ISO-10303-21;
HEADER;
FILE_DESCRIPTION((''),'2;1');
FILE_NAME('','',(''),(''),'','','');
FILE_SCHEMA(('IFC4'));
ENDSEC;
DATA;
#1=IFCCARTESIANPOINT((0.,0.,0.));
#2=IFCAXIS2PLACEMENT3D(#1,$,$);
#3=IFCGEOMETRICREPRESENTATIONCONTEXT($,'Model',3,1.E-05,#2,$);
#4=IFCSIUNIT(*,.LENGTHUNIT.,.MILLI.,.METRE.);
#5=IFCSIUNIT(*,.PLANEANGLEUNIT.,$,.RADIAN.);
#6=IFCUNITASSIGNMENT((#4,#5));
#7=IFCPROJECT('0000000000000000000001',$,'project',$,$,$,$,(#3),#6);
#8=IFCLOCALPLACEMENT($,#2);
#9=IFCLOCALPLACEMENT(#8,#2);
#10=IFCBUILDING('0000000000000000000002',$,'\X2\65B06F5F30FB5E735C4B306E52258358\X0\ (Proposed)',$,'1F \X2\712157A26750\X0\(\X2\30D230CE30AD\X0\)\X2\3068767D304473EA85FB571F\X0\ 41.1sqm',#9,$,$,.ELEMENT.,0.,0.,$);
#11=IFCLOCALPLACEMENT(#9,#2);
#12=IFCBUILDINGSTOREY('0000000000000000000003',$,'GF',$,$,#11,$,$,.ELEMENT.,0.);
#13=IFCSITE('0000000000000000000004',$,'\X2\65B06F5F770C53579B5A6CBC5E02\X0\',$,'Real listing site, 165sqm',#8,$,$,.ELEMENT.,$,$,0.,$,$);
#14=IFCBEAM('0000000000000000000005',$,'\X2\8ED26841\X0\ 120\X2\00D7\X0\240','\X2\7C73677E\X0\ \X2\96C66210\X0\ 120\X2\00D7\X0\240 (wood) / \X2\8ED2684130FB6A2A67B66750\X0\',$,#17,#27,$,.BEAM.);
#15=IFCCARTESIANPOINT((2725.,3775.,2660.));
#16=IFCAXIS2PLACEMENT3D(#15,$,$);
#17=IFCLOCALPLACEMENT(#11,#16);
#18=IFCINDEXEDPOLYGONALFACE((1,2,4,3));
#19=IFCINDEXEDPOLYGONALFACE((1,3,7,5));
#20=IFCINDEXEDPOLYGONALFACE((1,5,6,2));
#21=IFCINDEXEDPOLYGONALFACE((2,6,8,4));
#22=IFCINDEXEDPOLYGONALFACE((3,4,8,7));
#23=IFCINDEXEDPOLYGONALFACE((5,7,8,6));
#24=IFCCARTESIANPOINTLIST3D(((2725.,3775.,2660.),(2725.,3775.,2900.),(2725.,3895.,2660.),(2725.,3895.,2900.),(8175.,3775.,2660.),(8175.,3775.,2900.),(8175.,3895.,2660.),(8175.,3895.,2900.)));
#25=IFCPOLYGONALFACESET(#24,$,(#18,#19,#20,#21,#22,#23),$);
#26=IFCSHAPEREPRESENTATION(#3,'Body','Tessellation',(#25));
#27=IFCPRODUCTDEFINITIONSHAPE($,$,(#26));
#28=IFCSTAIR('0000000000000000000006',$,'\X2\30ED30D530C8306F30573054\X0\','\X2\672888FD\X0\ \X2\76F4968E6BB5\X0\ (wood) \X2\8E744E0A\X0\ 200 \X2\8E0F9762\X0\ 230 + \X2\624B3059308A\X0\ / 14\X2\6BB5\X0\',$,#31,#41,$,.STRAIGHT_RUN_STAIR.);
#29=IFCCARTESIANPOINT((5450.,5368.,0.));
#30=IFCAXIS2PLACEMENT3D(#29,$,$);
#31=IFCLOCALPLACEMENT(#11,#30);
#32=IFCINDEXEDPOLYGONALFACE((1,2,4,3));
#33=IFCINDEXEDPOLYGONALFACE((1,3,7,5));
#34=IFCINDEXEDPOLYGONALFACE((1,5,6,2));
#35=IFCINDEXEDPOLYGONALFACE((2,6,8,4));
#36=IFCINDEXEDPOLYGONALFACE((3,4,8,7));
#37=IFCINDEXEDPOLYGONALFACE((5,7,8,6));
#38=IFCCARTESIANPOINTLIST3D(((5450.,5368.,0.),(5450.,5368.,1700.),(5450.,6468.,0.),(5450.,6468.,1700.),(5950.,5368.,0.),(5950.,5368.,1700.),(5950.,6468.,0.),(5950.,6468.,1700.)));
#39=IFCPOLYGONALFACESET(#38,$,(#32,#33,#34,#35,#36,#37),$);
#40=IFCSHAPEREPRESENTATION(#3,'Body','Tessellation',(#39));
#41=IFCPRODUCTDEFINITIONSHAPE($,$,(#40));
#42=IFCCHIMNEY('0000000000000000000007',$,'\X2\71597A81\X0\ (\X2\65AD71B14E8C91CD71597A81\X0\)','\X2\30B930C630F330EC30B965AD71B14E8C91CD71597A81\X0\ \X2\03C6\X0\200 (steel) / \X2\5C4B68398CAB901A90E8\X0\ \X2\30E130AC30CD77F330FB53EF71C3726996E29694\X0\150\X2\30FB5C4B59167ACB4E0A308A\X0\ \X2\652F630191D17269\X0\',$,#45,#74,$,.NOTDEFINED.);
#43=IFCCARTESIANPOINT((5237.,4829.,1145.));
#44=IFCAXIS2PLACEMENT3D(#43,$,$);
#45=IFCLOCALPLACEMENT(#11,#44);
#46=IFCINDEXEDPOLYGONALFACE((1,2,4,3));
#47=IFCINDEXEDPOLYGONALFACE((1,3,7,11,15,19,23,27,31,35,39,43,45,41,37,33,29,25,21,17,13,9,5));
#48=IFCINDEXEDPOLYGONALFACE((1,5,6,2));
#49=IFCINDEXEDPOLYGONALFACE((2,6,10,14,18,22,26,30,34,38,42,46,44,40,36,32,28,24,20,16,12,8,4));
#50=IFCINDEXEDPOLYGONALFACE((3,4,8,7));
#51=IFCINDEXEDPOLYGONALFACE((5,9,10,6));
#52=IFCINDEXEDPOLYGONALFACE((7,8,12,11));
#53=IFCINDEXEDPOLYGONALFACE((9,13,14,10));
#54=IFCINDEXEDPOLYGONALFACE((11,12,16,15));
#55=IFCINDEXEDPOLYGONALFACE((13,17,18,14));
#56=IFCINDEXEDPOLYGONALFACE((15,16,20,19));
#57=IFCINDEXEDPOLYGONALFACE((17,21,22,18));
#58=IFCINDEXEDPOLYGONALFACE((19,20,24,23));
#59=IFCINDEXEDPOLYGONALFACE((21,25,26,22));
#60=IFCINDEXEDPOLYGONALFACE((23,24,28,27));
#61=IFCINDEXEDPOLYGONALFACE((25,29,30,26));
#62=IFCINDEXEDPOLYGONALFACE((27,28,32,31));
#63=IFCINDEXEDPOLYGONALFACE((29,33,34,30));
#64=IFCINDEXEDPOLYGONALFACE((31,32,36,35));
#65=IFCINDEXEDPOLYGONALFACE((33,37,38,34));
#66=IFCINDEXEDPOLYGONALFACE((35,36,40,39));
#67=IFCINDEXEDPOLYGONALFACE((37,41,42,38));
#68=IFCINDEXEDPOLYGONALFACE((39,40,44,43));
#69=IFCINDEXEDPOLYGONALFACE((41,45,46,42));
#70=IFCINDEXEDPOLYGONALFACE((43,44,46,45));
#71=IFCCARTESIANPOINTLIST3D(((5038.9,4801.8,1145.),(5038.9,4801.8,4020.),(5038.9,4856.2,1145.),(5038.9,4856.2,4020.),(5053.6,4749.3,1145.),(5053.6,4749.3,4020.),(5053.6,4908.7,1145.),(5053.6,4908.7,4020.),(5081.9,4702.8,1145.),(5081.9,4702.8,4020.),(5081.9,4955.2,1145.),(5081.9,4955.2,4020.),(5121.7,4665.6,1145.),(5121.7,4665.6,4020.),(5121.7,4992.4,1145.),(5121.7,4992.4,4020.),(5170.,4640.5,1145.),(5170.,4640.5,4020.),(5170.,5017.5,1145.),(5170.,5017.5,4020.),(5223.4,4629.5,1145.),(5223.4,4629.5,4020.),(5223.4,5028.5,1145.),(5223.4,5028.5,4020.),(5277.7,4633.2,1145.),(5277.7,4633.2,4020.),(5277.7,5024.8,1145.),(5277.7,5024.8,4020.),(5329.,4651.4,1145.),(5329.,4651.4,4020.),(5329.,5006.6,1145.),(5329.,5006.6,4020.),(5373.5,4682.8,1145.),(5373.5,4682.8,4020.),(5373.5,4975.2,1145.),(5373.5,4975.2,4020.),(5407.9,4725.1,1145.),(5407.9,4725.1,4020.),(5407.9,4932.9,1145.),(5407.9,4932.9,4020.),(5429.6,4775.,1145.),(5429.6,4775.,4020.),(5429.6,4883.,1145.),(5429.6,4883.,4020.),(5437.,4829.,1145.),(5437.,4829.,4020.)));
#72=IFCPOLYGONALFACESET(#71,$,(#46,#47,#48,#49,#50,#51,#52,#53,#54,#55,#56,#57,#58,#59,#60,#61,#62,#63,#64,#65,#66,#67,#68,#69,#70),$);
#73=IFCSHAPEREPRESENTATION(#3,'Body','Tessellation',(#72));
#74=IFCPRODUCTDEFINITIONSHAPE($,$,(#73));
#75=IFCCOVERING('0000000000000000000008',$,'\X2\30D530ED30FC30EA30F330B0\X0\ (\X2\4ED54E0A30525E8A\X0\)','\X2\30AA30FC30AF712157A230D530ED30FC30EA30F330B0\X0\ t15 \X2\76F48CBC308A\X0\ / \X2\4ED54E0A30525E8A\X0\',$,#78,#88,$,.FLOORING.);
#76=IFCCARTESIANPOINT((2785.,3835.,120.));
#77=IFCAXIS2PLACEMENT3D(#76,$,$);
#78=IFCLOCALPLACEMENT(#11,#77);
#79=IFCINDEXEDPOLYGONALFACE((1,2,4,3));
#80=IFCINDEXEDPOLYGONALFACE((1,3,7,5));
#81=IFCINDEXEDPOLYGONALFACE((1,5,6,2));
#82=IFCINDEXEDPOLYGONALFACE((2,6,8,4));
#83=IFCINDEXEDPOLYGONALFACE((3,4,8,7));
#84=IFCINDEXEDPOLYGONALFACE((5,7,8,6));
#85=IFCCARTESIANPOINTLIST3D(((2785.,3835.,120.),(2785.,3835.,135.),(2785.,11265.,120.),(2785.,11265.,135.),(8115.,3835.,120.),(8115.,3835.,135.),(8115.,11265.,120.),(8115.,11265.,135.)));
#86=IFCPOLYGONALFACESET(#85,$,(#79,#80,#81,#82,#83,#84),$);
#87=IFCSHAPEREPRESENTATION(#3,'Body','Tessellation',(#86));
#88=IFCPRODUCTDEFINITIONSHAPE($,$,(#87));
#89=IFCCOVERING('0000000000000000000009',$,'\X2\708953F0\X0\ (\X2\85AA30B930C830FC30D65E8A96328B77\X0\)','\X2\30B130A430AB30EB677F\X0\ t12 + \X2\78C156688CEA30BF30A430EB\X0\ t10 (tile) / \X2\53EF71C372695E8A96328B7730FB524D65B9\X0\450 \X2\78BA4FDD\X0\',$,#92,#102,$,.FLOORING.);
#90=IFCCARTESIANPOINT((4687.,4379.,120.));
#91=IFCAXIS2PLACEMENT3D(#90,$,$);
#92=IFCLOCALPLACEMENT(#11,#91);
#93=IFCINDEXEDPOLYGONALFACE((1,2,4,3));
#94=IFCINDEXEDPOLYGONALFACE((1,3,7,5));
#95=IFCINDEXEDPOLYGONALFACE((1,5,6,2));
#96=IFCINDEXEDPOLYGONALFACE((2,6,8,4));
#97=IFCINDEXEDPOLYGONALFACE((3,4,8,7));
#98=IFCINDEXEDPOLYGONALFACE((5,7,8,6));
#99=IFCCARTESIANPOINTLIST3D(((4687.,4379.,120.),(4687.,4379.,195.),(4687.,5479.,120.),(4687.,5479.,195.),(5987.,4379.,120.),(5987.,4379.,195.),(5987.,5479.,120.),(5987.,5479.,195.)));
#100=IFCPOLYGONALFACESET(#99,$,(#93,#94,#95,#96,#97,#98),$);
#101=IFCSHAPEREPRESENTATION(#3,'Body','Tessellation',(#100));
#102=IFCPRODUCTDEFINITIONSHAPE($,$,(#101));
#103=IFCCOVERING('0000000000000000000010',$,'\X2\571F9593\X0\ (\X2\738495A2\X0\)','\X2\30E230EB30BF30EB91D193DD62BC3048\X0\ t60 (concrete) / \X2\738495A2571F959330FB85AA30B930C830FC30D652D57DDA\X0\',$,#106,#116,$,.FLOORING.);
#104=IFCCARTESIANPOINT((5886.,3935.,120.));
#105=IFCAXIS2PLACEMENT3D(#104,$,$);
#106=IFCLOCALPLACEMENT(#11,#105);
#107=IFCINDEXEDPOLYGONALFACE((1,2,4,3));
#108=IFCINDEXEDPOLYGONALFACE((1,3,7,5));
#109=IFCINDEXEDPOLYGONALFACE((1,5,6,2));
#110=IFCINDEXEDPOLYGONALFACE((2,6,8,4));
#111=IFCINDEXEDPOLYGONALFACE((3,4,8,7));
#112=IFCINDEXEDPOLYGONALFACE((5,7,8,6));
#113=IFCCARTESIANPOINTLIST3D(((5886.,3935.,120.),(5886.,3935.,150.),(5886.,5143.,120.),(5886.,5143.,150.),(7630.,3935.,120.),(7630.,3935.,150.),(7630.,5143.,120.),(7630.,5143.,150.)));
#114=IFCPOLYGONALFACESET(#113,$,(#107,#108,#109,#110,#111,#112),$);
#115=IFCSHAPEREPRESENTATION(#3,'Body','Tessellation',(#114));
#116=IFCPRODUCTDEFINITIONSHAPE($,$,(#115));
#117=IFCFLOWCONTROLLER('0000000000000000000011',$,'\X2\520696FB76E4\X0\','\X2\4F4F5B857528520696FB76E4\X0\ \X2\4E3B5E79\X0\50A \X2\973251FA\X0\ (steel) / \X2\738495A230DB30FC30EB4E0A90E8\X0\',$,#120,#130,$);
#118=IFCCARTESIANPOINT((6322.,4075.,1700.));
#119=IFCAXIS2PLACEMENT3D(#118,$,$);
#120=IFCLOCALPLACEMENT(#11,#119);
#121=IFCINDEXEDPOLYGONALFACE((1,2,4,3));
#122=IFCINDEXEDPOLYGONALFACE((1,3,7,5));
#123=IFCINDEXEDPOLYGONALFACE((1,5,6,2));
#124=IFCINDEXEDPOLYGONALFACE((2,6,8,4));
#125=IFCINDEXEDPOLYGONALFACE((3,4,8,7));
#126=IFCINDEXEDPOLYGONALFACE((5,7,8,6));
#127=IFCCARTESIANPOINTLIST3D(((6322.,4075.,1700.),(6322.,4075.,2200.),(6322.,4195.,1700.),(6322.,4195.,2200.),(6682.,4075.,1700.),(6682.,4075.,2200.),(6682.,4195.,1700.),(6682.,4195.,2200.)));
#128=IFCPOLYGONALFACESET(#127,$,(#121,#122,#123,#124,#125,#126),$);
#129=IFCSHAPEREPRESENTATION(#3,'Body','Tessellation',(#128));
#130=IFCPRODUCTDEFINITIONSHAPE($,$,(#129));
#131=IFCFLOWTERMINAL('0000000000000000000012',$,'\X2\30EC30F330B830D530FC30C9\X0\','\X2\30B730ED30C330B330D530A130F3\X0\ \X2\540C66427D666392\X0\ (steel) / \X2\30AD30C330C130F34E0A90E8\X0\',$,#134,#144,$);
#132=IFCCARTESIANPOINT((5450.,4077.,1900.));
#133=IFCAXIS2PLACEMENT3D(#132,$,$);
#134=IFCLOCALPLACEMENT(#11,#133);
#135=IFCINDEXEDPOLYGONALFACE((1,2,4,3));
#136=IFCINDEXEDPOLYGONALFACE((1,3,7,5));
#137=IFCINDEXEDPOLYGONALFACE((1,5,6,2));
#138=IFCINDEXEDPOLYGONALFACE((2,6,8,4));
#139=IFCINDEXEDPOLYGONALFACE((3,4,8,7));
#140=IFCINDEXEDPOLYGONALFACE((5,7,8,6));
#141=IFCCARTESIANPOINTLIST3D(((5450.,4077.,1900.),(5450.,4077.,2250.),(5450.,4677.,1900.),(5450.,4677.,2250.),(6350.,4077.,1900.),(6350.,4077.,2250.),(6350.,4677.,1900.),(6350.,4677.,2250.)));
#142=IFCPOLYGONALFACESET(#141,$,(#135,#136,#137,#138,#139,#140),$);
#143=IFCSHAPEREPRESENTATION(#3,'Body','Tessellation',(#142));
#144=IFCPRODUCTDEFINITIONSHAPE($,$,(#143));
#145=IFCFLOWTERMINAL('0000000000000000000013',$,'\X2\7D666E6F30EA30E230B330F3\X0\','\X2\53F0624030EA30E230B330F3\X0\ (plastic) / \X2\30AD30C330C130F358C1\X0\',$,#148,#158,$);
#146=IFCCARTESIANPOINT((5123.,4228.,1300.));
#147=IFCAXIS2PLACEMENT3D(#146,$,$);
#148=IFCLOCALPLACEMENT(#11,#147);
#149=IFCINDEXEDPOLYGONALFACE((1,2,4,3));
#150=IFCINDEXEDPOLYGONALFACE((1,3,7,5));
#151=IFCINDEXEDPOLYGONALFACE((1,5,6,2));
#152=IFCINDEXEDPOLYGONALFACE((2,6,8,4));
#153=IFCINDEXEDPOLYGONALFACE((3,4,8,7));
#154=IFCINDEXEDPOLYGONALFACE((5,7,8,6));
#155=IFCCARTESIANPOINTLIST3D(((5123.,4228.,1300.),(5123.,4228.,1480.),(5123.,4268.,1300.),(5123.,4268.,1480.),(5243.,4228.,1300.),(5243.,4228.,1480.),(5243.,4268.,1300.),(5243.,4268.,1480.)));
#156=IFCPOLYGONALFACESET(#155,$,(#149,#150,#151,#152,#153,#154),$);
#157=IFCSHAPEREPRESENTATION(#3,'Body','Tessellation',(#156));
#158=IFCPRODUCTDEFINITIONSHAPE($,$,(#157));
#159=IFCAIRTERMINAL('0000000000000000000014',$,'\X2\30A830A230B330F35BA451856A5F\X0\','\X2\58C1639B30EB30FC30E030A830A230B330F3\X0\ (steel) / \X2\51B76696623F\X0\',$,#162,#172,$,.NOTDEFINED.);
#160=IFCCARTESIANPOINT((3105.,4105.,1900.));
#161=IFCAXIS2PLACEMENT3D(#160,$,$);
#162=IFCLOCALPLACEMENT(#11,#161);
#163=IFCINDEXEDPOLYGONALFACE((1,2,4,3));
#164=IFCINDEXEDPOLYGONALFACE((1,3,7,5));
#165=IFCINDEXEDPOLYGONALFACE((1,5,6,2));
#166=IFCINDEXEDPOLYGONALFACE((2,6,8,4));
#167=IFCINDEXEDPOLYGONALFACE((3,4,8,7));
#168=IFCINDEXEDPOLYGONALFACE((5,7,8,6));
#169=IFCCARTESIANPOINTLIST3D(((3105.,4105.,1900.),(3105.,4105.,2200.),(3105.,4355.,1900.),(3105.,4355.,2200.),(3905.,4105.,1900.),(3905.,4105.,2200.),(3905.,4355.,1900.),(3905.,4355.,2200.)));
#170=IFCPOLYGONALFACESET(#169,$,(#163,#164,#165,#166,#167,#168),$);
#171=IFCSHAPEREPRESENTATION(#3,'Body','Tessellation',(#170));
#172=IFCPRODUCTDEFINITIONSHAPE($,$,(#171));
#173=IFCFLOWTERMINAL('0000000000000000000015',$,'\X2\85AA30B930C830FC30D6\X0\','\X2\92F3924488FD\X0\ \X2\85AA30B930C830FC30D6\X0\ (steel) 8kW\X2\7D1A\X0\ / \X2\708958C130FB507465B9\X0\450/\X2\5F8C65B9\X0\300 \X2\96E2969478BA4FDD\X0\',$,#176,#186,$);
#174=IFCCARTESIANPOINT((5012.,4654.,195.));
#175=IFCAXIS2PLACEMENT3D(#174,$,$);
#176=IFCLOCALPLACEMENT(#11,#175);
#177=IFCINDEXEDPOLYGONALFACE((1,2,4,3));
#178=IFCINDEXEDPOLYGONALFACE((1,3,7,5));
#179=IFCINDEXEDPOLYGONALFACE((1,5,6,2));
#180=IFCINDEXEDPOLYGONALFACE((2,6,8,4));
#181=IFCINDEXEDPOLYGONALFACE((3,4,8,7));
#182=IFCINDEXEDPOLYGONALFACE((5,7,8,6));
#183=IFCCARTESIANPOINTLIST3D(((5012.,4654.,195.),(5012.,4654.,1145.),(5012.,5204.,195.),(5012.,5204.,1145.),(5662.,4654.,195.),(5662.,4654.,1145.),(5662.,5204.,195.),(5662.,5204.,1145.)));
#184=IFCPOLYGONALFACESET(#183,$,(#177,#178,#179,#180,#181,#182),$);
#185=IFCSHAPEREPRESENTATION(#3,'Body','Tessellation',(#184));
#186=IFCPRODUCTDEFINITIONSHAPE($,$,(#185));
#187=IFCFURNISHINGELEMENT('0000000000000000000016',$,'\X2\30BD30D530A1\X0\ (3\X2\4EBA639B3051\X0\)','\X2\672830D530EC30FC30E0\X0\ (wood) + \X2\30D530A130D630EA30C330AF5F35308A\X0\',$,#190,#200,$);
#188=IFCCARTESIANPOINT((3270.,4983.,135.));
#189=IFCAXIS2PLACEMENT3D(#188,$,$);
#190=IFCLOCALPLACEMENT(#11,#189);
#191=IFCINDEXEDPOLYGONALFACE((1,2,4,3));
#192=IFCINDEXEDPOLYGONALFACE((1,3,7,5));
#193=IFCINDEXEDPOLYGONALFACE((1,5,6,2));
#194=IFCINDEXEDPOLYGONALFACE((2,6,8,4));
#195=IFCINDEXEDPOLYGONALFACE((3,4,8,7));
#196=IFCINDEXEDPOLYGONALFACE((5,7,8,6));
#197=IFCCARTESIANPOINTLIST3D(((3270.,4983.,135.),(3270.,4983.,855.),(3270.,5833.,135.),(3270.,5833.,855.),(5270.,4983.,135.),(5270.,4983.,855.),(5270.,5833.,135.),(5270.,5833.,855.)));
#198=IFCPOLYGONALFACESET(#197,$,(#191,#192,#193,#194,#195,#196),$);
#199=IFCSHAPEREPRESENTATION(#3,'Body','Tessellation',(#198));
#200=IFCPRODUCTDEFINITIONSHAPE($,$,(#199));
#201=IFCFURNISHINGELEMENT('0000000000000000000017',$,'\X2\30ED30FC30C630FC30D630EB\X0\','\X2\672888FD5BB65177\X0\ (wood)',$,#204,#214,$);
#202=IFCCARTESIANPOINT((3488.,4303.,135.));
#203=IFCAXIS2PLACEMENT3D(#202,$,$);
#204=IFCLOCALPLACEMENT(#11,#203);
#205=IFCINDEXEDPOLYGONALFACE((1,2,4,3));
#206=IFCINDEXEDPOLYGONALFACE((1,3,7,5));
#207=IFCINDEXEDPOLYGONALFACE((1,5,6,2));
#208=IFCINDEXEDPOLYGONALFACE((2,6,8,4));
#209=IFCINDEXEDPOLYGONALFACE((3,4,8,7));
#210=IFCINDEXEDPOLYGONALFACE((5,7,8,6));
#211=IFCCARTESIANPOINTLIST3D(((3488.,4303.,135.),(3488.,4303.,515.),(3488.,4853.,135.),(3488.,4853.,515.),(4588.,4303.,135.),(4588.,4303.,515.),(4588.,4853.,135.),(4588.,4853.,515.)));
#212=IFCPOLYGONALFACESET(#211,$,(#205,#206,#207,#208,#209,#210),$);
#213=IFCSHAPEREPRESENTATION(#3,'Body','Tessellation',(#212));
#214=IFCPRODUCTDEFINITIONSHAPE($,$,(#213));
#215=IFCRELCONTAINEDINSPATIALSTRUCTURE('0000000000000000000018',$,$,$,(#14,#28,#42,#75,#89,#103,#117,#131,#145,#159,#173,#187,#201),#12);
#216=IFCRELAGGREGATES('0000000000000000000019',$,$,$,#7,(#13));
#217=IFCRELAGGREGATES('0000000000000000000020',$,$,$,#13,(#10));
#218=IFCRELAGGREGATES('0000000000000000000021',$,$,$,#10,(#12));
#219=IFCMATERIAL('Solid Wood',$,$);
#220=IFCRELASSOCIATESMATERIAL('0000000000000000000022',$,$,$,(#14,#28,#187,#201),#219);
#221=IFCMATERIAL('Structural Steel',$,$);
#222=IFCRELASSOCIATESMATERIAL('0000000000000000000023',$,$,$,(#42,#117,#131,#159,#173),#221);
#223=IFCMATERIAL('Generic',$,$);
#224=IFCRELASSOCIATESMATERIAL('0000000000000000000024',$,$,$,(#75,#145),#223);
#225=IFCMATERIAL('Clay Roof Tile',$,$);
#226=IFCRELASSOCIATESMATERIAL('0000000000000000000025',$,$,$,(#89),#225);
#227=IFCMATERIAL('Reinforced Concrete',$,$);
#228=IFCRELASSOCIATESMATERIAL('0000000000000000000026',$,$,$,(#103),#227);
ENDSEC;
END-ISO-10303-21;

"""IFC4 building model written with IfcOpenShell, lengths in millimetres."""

from ifc_helpers import new_model, si_unit, frame, frame_2d, origin, origin_2d, place, context, project, spatial, rectangle, circle, extrude, material, element, save


model = new_model("IFC4")

# Units and contexts
model_context = context("Model", 3, precision=1e-05, world=origin())
ifc_project = project(units=[si_unit("LENGTHUNIT", "METRE", prefix="MILLI"), si_unit("PLANEANGLEUNIT", "RADIAN")], contexts=[model_context])

# Site, building, storey
site_placement = place(None, origin())
site = spatial("IfcSite", under=ifc_project, at=site_placement, Name="新潟県南魚沼市", ObjectType="Real listing site, 165sqm", CompositionType="ELEMENT", RefElevation=0.0)
building_placement = place(site_placement, origin())
building = spatial("IfcBuilding", under=site, at=building_placement, Name="新潟・平屋の別荘 (Proposed)", ObjectType="1F 無垢材(ヒノキ)と白い珪藻土 41.1sqm", CompositionType="ELEMENT", ElevationOfRefHeight=0.0, ElevationOfTerrain=0.0)
storey_placement = place(building_placement, origin())
storey = spatial("IfcBuildingStorey", under=building, at=storey_placement, Name="GF", CompositionType="ELEMENT", Elevation=0.0)

# Beam
ifc_material_1 = material(Name="Solid Wood")
beam_1_placement = place(storey_placement, frame((2725.0, 3775.0, 2660.0)))
element("IfcBeam", 1, at=beam_1_placement, inside=storey, material=ifc_material_1, Name="軒桁 120×240", Description="米松 集成 120×240 (wood) / 軒桁・横架材", PredefinedType="BEAM", context=model_context, shape_type="SweptSolid", body=[
    extrude(rectangle(XDim=5450.0, YDim=120.0, at=frame_2d((2725.0, 60.0))), frame((2725.0, 3775.0, 2660.0)), (0.0, 0.0, 1.0), 240.0),
])

# Stair
stair_placement = place(storey_placement, frame((5450.0, 5368.0, 0.0)))
element("IfcStair", 2, at=stair_placement, inside=storey, material=ifc_material_1, Name="ロフトはしご", Description="木製 直階段 (wood) 蹴上 200 踏面 230 + 手すり / 14段", PredefinedType="STRAIGHT_RUN_STAIR", context=model_context, shape_type="SweptSolid", body=[
    extrude(rectangle(XDim=500.0, YDim=1100.0, at=frame_2d((250.0, 550.0))), frame((5450.0, 5368.0, 0.0)), (0.0, 0.0, 1.0), 1700.0),
])

# Chimney
ifc_material_2 = material(Name="Structural Steel")
chimney_placement = place(storey_placement, frame((5237.0, 4829.0, 1145.0)))
element("IfcChimney", 3, at=chimney_placement, inside=storey, material=ifc_material_2, Name="煙突 (断熱二重煙突)", Description="ステンレス断熱二重煙突 φ200 (steel) / 屋根貫通部 メガネ石・可燃物離隔150・屋外立上り 支持金物", PredefinedType="NOTDEFINED", context=model_context, shape_type="SweptSolid", body=[
    extrude(circle(Radius=200.0, at=origin_2d()), frame((5237.0, 4829.0, 1145.0)), (0.0, 0.0, 1.0), 2875.0),
])

# Coverings
ifc_material_3 = material(Name="Generic")
covering_1_placement = place(storey_placement, frame((2785.0, 3835.0, 120.0)))
element("IfcCovering", 4, at=covering_1_placement, inside=storey, material=ifc_material_3, Name="フローリング (仕上げ床)", Description="オーク無垢フローリング t15 直貼り / 仕上げ床", PredefinedType="FLOORING", context=model_context, shape_type="SweptSolid", body=[
    extrude(rectangle(XDim=5330.0, YDim=7430.0, at=frame_2d((2665.0, 3715.0))), frame((2785.0, 3835.0, 120.0)), (0.0, 0.0, 1.0), 15.0),
])
ifc_material_4 = material(Name="Clay Roof Tile")
covering_2_placement = place(storey_placement, frame((4687.0, 4379.0, 120.0)))
element("IfcCovering", 5, at=covering_2_placement, inside=storey, material=ifc_material_4, Name="炉台 (薪ストーブ床防護)", Description="ケイカル板 t12 + 磁器質タイル t10 (tile) / 可燃物床防護・前方450 確保", PredefinedType="FLOORING", context=model_context, shape_type="SweptSolid", body=[
    extrude(rectangle(XDim=1300.0, YDim=1100.0, at=frame_2d((650.0, 550.0))), frame((4687.0, 4379.0, 120.0)), (0.0, 0.0, 1.0), 75.0),
])
ifc_material_5 = material(Name="Reinforced Concrete")
covering_3_placement = place(storey_placement, frame((5886.0, 3935.0, 120.0)))
element("IfcCovering", 6, at=covering_3_placement, inside=storey, material=ifc_material_5, Name="土間 (玄関)", Description="モルタル金鏝押え t60 (concrete) / 玄関土間・薪ストーブ動線", PredefinedType="FLOORING", context=model_context, shape_type="SweptSolid", body=[
    extrude(rectangle(XDim=1744.0, YDim=1208.0, at=frame_2d((872.0, 604.0))), frame((5886.0, 3935.0, 120.0)), (0.0, 0.0, 1.0), 30.0),
])

# Flow controller
flow_controller_placement = place(storey_placement, frame((6322.0, 4075.0, 1700.0)))
element("IfcFlowController", 7, at=flow_controller_placement, inside=storey, material=ifc_material_2, Name="分電盤", Description="住宅用分電盤 主幹50A 露出 (steel) / 玄関ホール上部", context=model_context, shape_type="SweptSolid", body=[
    extrude(rectangle(XDim=360.0, YDim=120.0, at=frame_2d((180.0, 60.0))), frame((6322.0, 4075.0, 1700.0)), (0.0, 0.0, 1.0), 500.0),
])

# Flow terminals
flow_terminal_1_placement = place(storey_placement, frame((5450.0, 4077.0, 1900.0)))
element("IfcFlowTerminal", 8, at=flow_terminal_1_placement, inside=storey, material=ifc_material_2, Name="レンジフード", Description="シロッコファン 同時給排 (steel) / キッチン上部", context=model_context, shape_type="SweptSolid", body=[
    extrude(rectangle(XDim=900.0, YDim=600.0, at=frame_2d((450.0, 300.0))), frame((5450.0, 4077.0, 1900.0)), (0.0, 0.0, 1.0), 350.0),
])
flow_terminal_2_placement = place(storey_placement, frame((5123.0, 4228.0, 1300.0)))
element("IfcFlowTerminal", 9, at=flow_terminal_2_placement, inside=storey, material=ifc_material_3, Name="給湯リモコン", Description="台所リモコン (plastic) / キッチン壁", context=model_context, shape_type="SweptSolid", body=[
    extrude(rectangle(XDim=120.0, YDim=40.0, at=frame_2d((60.0, 20.0))), frame((5123.0, 4228.0, 1300.0)), (0.0, 0.0, 1.0), 180.0),
])

# Air terminal
air_terminal_placement = place(storey_placement, frame((3105.0, 4105.0, 1900.0)))
element("IfcAirTerminal", 10, at=air_terminal_placement, inside=storey, material=ifc_material_2, Name="エアコン室内機", Description="壁掛ルームエアコン (steel) / 冷暖房", PredefinedType="NOTDEFINED", context=model_context, shape_type="SweptSolid", body=[
    extrude(rectangle(XDim=800.0, YDim=250.0, at=frame_2d((400.0, 125.0))), frame((3105.0, 4105.0, 1900.0)), (0.0, 0.0, 1.0), 300.0),
])

# Flow terminal
flow_terminal_3_placement = place(storey_placement, frame((5012.0, 4654.0, 195.0)))
element("IfcFlowTerminal", 11, at=flow_terminal_3_placement, inside=storey, material=ifc_material_2, Name="薪ストーブ", Description="鋳鉄製 薪ストーブ (steel) 8kW級 / 炉壁・側方450/後方300 離隔確保", context=model_context, shape_type="SweptSolid", body=[
    extrude(rectangle(XDim=650.0, YDim=550.0, at=frame_2d((325.0, 275.0))), frame((5012.0, 4654.0, 195.0)), (0.0, 0.0, 1.0), 950.0),
])

# Furnishing elements
furnishing_1_placement = place(storey_placement, frame((3270.0, 4983.0, 135.0)))
element("IfcFurnishingElement", 12, at=furnishing_1_placement, inside=storey, material=ifc_material_1, Name="ソファ (3人掛け)", Description="木フレーム (wood) + ファブリック張り", context=model_context, shape_type="SweptSolid", body=[
    extrude(rectangle(XDim=2000.0, YDim=850.0, at=frame_2d((1000.0, 425.0))), frame((3270.0, 4983.0, 135.0)), (0.0, 0.0, 1.0), 720.0),
])
furnishing_2_placement = place(storey_placement, frame((3488.0, 4303.0, 135.0)))
element("IfcFurnishingElement", 13, at=furnishing_2_placement, inside=storey, material=ifc_material_1, Name="ローテーブル", Description="木製家具 (wood)", context=model_context, shape_type="SweptSolid", body=[
    extrude(rectangle(XDim=1100.0, YDim=550.0, at=frame_2d((550.0, 275.0))), frame((3488.0, 4303.0, 135.0)), (0.0, 0.0, 1.0), 380.0),
])

save(model, "model.ifc")
